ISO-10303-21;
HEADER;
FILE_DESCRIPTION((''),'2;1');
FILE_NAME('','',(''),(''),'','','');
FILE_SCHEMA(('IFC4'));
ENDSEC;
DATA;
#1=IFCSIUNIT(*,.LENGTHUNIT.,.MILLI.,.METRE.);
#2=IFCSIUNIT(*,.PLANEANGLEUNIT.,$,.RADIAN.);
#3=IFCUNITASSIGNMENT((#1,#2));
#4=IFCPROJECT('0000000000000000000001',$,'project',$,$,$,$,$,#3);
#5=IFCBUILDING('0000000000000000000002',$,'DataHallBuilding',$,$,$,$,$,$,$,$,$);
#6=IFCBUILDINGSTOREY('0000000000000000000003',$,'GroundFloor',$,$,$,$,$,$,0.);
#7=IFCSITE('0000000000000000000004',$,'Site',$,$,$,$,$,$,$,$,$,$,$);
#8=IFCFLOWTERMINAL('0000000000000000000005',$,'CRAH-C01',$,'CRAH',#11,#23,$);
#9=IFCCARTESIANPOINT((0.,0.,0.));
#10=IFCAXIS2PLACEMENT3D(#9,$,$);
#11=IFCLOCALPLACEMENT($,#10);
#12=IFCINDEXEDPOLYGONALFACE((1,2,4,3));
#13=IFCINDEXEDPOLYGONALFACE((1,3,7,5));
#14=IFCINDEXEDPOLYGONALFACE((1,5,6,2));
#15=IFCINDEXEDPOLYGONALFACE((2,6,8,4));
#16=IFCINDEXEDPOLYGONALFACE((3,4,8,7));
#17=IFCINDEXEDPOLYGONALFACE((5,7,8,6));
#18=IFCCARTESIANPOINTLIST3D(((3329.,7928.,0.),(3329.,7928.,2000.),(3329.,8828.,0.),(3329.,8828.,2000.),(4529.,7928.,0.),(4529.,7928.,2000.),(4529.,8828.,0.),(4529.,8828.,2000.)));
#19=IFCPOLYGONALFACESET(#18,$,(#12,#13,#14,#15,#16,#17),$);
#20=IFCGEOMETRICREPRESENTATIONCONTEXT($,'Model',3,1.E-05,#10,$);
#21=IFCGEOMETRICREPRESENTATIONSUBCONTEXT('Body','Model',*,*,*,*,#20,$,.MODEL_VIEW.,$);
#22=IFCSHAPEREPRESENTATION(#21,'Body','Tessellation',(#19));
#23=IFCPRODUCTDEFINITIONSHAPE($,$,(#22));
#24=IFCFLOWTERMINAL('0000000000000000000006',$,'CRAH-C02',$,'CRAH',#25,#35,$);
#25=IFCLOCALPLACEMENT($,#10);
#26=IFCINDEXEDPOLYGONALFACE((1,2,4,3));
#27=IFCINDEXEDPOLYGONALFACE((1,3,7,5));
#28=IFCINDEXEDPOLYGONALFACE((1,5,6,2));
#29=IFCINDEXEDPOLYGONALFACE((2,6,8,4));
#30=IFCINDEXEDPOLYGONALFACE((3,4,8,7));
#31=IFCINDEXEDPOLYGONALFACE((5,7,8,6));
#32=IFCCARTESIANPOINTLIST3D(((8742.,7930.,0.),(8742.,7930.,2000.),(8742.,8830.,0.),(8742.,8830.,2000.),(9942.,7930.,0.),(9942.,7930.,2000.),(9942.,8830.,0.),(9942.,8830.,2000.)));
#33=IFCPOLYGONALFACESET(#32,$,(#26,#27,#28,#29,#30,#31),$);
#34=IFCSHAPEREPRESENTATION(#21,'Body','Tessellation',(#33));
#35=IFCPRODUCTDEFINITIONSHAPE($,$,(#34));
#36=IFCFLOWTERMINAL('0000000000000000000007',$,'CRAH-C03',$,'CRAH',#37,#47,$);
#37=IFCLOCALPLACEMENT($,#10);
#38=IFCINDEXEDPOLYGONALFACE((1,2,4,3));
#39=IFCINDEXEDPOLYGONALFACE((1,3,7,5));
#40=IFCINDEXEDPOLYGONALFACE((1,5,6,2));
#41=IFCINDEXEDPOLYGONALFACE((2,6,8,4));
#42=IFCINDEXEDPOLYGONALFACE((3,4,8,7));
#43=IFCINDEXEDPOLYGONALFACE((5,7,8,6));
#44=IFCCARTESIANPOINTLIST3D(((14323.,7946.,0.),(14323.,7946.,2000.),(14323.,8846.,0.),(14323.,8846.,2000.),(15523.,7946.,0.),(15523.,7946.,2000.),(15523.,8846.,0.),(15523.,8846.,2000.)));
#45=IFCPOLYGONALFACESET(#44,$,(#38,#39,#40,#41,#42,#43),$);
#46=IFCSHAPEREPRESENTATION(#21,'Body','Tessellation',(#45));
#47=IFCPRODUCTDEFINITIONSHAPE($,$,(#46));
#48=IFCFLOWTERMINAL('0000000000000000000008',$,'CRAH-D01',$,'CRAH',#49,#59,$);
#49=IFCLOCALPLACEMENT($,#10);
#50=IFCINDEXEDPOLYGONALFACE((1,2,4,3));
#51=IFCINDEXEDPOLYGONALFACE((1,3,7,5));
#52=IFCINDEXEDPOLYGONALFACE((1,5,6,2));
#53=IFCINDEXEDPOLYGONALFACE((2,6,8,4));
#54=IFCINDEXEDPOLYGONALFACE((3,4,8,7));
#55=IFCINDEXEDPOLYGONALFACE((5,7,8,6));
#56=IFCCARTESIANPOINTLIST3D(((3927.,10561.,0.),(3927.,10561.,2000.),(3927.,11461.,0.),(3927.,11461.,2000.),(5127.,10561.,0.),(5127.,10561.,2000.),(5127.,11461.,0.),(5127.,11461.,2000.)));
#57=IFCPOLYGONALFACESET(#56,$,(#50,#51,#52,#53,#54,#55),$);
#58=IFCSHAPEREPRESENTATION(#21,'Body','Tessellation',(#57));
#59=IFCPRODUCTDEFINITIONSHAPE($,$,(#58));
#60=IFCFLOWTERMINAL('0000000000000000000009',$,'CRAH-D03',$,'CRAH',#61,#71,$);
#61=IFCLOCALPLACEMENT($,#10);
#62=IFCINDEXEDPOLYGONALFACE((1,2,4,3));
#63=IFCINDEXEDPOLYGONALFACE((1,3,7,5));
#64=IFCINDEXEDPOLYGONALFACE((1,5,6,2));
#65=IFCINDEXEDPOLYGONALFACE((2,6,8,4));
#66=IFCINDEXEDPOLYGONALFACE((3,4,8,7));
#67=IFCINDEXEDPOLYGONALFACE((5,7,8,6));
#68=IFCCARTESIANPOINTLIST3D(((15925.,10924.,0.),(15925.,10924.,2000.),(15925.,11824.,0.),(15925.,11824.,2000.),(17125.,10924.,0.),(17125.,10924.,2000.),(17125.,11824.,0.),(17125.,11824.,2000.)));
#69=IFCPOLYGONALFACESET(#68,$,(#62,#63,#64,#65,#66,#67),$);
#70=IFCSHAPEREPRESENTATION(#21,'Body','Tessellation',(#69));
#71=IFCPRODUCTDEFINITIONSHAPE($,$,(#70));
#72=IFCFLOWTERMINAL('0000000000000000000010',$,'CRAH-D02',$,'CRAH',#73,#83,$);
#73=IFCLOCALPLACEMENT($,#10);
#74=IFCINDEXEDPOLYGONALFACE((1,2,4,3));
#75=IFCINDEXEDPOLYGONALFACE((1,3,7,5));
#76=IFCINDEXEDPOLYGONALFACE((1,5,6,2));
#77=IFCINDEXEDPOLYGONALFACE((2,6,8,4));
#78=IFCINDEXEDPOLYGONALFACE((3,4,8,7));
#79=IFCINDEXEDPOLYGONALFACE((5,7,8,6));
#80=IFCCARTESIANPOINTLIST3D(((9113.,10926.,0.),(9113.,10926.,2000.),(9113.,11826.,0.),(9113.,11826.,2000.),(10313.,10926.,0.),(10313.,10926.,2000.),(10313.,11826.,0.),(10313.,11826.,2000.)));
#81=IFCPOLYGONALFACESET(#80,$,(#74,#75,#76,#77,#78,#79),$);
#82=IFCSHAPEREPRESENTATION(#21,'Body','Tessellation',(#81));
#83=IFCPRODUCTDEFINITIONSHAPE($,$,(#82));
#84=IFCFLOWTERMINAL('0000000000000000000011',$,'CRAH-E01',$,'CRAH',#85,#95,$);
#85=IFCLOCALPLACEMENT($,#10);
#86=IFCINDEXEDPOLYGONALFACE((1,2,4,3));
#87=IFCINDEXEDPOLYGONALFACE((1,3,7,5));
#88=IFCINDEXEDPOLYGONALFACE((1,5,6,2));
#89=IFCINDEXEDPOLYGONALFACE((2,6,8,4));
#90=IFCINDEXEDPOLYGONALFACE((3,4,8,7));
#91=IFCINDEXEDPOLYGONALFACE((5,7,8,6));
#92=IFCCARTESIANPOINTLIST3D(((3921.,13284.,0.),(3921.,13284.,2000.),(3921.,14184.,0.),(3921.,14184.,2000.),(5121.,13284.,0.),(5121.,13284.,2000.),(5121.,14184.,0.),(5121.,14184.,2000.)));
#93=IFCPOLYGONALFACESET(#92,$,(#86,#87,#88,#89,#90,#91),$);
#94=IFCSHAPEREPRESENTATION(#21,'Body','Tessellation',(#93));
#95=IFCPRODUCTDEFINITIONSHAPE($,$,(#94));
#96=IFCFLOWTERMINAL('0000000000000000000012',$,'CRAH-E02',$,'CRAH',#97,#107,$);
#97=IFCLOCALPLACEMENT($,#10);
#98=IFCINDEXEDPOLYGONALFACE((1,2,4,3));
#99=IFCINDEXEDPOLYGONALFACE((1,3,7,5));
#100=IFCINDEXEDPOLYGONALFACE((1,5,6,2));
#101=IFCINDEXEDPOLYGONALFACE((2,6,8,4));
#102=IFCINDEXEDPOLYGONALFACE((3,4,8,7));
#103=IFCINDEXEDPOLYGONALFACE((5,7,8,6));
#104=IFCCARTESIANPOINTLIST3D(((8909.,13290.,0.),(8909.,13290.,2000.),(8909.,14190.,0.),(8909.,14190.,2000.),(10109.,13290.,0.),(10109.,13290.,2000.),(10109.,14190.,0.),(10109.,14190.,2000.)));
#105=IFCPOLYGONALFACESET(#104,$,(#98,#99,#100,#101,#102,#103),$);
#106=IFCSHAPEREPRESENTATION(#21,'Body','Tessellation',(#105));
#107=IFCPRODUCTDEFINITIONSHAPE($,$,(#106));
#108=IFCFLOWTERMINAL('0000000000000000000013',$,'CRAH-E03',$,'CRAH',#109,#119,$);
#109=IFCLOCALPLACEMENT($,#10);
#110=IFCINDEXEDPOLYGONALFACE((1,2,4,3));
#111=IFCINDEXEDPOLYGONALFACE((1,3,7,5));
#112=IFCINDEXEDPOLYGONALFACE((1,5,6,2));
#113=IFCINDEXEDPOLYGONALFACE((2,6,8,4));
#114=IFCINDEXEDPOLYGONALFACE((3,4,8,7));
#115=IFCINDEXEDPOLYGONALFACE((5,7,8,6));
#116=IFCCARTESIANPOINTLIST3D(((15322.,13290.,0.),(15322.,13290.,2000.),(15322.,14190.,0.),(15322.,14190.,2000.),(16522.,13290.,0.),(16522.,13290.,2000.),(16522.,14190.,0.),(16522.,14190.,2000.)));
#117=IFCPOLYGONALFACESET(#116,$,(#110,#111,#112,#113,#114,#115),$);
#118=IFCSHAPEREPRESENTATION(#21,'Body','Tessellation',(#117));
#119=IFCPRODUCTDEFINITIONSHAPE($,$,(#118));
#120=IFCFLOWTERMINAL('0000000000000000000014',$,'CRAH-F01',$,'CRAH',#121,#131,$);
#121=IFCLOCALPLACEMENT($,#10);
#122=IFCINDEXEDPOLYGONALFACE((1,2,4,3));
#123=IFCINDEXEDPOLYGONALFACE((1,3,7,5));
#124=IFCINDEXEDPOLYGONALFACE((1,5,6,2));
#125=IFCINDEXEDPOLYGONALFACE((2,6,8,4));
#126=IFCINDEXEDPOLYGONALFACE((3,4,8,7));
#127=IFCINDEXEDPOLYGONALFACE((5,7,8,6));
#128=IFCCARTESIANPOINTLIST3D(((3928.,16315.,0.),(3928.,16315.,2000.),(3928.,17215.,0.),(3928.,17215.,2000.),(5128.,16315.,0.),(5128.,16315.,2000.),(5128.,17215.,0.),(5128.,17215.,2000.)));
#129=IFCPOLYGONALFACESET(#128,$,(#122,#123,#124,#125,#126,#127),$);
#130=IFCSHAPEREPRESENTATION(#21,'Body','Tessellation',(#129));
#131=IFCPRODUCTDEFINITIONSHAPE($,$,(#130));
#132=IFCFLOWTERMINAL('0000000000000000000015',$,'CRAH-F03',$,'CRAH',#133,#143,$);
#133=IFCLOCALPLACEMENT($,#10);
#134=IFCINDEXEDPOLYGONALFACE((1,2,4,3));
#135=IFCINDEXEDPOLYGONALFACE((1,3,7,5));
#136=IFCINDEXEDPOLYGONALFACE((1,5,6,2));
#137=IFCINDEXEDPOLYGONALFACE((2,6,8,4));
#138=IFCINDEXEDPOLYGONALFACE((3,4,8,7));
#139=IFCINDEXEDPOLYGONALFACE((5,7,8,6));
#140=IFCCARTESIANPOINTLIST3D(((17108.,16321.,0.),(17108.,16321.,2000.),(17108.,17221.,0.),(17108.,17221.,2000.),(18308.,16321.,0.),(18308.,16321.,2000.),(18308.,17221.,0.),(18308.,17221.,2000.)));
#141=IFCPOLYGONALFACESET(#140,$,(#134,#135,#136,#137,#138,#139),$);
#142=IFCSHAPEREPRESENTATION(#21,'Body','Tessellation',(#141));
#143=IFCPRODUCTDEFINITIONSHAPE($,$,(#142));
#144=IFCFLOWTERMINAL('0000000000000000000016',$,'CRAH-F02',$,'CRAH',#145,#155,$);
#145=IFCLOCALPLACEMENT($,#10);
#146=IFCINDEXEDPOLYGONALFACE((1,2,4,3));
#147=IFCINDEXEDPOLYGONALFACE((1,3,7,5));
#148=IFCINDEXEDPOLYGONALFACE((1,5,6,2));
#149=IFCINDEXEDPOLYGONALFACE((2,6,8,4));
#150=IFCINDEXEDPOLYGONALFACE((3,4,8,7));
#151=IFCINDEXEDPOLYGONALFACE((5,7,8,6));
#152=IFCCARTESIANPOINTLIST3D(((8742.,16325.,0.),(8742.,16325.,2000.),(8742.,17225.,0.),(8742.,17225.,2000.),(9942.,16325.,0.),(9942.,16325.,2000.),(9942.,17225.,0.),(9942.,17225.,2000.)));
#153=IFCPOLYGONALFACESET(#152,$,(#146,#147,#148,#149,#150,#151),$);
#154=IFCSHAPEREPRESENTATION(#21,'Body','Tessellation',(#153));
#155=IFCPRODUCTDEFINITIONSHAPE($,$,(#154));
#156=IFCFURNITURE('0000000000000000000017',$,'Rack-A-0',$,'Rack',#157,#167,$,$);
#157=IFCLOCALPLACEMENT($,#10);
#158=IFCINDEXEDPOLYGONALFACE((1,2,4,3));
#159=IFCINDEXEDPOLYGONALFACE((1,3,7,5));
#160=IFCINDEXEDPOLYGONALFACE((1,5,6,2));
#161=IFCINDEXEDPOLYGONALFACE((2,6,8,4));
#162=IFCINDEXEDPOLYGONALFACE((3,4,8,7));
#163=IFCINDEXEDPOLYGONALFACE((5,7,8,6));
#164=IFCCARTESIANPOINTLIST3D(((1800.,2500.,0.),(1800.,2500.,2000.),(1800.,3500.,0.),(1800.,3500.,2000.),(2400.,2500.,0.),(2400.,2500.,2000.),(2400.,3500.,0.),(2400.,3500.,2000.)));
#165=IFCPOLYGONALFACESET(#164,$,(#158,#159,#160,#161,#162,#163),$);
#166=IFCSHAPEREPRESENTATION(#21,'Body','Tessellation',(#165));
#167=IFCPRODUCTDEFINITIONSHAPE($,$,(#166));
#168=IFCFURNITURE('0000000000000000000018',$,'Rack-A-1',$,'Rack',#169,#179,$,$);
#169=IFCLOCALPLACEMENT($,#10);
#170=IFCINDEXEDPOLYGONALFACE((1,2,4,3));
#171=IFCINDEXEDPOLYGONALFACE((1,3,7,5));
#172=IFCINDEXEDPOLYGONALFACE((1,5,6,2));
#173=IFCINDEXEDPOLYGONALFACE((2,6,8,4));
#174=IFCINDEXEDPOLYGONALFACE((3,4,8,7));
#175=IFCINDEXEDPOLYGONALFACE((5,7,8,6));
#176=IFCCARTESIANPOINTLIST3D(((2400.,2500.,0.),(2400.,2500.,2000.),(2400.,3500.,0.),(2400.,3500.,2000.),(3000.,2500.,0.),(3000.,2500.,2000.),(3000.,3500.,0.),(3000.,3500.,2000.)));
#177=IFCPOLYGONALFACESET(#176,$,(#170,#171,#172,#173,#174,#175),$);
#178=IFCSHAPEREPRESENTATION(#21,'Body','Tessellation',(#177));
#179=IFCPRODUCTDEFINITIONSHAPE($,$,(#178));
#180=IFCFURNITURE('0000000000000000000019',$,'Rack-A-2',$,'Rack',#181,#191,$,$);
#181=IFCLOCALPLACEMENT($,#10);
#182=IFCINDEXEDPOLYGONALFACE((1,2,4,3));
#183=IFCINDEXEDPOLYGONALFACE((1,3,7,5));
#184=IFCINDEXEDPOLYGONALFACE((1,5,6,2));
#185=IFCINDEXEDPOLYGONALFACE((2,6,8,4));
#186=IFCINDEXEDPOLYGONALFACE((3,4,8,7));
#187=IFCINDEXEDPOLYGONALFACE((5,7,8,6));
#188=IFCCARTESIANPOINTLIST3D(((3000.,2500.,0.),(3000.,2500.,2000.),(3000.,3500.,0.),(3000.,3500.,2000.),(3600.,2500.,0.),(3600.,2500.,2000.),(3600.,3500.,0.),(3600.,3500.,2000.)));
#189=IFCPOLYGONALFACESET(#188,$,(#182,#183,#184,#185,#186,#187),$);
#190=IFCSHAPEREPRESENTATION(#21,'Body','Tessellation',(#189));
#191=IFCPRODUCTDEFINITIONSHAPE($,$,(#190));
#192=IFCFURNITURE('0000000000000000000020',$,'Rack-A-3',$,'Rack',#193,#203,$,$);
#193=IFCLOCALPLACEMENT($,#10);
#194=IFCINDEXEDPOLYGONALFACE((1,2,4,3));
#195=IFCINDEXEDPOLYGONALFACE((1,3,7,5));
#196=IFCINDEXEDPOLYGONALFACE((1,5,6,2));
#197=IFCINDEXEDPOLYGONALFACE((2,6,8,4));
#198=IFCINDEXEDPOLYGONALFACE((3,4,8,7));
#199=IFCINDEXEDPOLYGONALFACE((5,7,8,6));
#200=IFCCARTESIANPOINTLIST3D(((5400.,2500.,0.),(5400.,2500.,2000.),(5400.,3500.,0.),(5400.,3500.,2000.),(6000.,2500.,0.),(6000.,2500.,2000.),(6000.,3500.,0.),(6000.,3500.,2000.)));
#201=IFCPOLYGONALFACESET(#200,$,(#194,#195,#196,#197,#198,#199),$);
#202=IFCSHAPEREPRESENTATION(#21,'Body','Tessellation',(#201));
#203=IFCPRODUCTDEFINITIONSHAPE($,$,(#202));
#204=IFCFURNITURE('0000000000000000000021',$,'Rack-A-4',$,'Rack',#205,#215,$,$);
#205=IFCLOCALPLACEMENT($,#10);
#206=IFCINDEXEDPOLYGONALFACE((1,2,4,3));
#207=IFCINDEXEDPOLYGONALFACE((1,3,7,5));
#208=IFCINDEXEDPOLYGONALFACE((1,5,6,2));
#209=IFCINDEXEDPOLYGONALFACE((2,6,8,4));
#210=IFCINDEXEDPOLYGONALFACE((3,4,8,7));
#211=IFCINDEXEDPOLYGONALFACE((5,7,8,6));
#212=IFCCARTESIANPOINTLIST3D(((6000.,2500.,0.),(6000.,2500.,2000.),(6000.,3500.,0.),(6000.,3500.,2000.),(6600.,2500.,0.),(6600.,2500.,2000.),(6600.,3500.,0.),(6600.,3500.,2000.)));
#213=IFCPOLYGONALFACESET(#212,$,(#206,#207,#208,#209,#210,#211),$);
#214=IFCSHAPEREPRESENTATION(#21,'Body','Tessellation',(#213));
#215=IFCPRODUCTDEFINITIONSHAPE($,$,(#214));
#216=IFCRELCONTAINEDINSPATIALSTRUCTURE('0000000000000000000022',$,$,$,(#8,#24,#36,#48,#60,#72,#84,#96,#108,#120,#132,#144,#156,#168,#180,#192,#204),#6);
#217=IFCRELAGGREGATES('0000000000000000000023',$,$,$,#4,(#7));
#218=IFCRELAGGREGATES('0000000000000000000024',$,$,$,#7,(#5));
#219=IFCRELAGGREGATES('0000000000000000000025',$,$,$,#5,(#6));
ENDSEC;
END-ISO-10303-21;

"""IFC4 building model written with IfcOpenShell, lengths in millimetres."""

from ifc_helpers import new_model, si_unit, frame, origin, place, context, subcontext, project, spatial, rectangle, extrude, element, save


model = new_model("IFC4")

# Units and contexts
model_context = context("Model", 3, precision=1e-05, world=origin())
body_context = subcontext(model_context, "Body", "Model", "MODEL_VIEW")
ifc_project = project(units=[si_unit("LENGTHUNIT", "METRE", prefix="MILLI"), si_unit("PLANEANGLEUNIT", "RADIAN")])

# Site, building, storey
site = spatial("IfcSite", under=ifc_project, Name="Site")
building = spatial("IfcBuilding", under=site, Name="DataHallBuilding")
storey = spatial("IfcBuildingStorey", under=building, Name="GroundFloor", Elevation=0.0)

# Flow terminals
flow_terminal_1_placement = place(None, origin())
element("IfcFlowTerminal", 1, at=flow_terminal_1_placement, inside=storey, Name="CRAH-C01", ObjectType="CRAH", context=body_context, shape_type="SweptSolid", body=[
    extrude(rectangle(XDim=1200.0, YDim=900.0), frame((3929.0, 8378.0, 0.0), z_axis=(0.0, 0.0, 1.0), x_axis=(1.0, 0.0, 0.0)), (0.0, 0.0, 1.0), 2000.0),
])
flow_terminal_2_placement = place(None, origin())
element("IfcFlowTerminal", 2, at=flow_terminal_2_placement, inside=storey, Name="CRAH-C02", ObjectType="CRAH", context=body_context, shape_type="SweptSolid", body=[
    extrude(rectangle(XDim=1200.0, YDim=900.0), frame((9342.0, 8380.0, 0.0), z_axis=(0.0, 0.0, 1.0), x_axis=(1.0, 0.0, 0.0)), (0.0, 0.0, 1.0), 2000.0),
])
flow_terminal_3_placement = place(None, origin())
element("IfcFlowTerminal", 3, at=flow_terminal_3_placement, inside=storey, Name="CRAH-C03", ObjectType="CRAH", context=body_context, shape_type="SweptSolid", body=[
    extrude(rectangle(XDim=1200.0, YDim=900.0), frame((14923.0, 8396.0, 0.0), z_axis=(0.0, 0.0, 1.0), x_axis=(1.0, 0.0, 0.0)), (0.0, 0.0, 1.0), 2000.0),
])
flow_terminal_4_placement = place(None, origin())
element("IfcFlowTerminal", 4, at=flow_terminal_4_placement, inside=storey, Name="CRAH-D01", ObjectType="CRAH", context=body_context, shape_type="SweptSolid", body=[
    extrude(rectangle(XDim=1200.0, YDim=900.0), frame((4527.0, 11011.0, 0.0), z_axis=(0.0, 0.0, 1.0), x_axis=(1.0, 0.0, 0.0)), (0.0, 0.0, 1.0), 2000.0),
])
flow_terminal_5_placement = place(None, origin())
element("IfcFlowTerminal", 5, at=flow_terminal_5_placement, inside=storey, Name="CRAH-D03", ObjectType="CRAH", context=body_context, shape_type="SweptSolid", body=[
    extrude(rectangle(XDim=1200.0, YDim=900.0), frame((16525.0, 11374.0, 0.0), z_axis=(0.0, 0.0, 1.0), x_axis=(1.0, 0.0, 0.0)), (0.0, 0.0, 1.0), 2000.0),
])
flow_terminal_6_placement = place(None, origin())
element("IfcFlowTerminal", 6, at=flow_terminal_6_placement, inside=storey, Name="CRAH-D02", ObjectType="CRAH", context=body_context, shape_type="SweptSolid", body=[
    extrude(rectangle(XDim=1200.0, YDim=900.0), frame((9713.0, 11376.0, 0.0), z_axis=(0.0, 0.0, 1.0), x_axis=(1.0, 0.0, 0.0)), (0.0, 0.0, 1.0), 2000.0),
])
flow_terminal_7_placement = place(None, origin())
element("IfcFlowTerminal", 7, at=flow_terminal_7_placement, inside=storey, Name="CRAH-E01", ObjectType="CRAH", context=body_context, shape_type="SweptSolid", body=[
    extrude(rectangle(XDim=1200.0, YDim=900.0), frame((4521.0, 13734.0, 0.0), z_axis=(0.0, 0.0, 1.0), x_axis=(1.0, 0.0, 0.0)), (0.0, 0.0, 1.0), 2000.0),
])
flow_terminal_8_placement = place(None, origin())
element("IfcFlowTerminal", 8, at=flow_terminal_8_placement, inside=storey, Name="CRAH-E02", ObjectType="CRAH", context=body_context, shape_type="SweptSolid", body=[
    extrude(rectangle(XDim=1200.0, YDim=900.0), frame((9509.0, 13740.0, 0.0), z_axis=(0.0, 0.0, 1.0), x_axis=(1.0, 0.0, 0.0)), (0.0, 0.0, 1.0), 2000.0),
])
flow_terminal_9_placement = place(None, origin())
element("IfcFlowTerminal", 9, at=flow_terminal_9_placement, inside=storey, Name="CRAH-E03", ObjectType="CRAH", context=body_context, shape_type="SweptSolid", body=[
    extrude(rectangle(XDim=1200.0, YDim=900.0), frame((15922.0, 13740.0, 0.0), z_axis=(0.0, 0.0, 1.0), x_axis=(1.0, 0.0, 0.0)), (0.0, 0.0, 1.0), 2000.0),
])
flow_terminal_10_placement = place(None, origin())
element("IfcFlowTerminal", 10, at=flow_terminal_10_placement, inside=storey, Name="CRAH-F01", ObjectType="CRAH", context=body_context, shape_type="SweptSolid", body=[
    extrude(rectangle(XDim=1200.0, YDim=900.0), frame((4528.0, 16765.0, 0.0), z_axis=(0.0, 0.0, 1.0), x_axis=(1.0, 0.0, 0.0)), (0.0, 0.0, 1.0), 2000.0),
])
flow_terminal_11_placement = place(None, origin())
element("IfcFlowTerminal", 11, at=flow_terminal_11_placement, inside=storey, Name="CRAH-F03", ObjectType="CRAH", context=body_context, shape_type="SweptSolid", body=[
    extrude(rectangle(XDim=1200.0, YDim=900.0), frame((17708.0, 16771.0, 0.0), z_axis=(0.0, 0.0, 1.0), x_axis=(1.0, 0.0, 0.0)), (0.0, 0.0, 1.0), 2000.0),
])
flow_terminal_12_placement = place(None, origin())
element("IfcFlowTerminal", 12, at=flow_terminal_12_placement, inside=storey, Name="CRAH-F02", ObjectType="CRAH", context=body_context, shape_type="SweptSolid", body=[
    extrude(rectangle(XDim=1200.0, YDim=900.0), frame((9342.0, 16775.0, 0.0), z_axis=(0.0, 0.0, 1.0), x_axis=(1.0, 0.0, 0.0)), (0.0, 0.0, 1.0), 2000.0),
])

# Furniture
furniture_1_placement = place(None, origin())
element("IfcFurniture", 13, at=furniture_1_placement, inside=storey, Name="Rack-A-0", ObjectType="Rack", context=body_context, shape_type="SweptSolid", body=[
    extrude(rectangle(XDim=600.0, YDim=1000.0), frame((2100.0, 3000.0, 0.0), z_axis=(0.0, 0.0, 1.0), x_axis=(1.0, 0.0, 0.0)), (0.0, 0.0, 1.0), 2000.0),
])
furniture_2_placement = place(None, origin())
element("IfcFurniture", 14, at=furniture_2_placement, inside=storey, Name="Rack-A-1", ObjectType="Rack", context=body_context, shape_type="SweptSolid", body=[
    extrude(rectangle(XDim=600.0, YDim=1000.0), frame((2700.0, 3000.0, 0.0), z_axis=(0.0, 0.0, 1.0), x_axis=(1.0, 0.0, 0.0)), (0.0, 0.0, 1.0), 2000.0),
])
furniture_3_placement = place(None, origin())
element("IfcFurniture", 15, at=furniture_3_placement, inside=storey, Name="Rack-A-2", ObjectType="Rack", context=body_context, shape_type="SweptSolid", body=[
    extrude(rectangle(XDim=600.0, YDim=1000.0), frame((3300.0, 3000.0, 0.0), z_axis=(0.0, 0.0, 1.0), x_axis=(1.0, 0.0, 0.0)), (0.0, 0.0, 1.0), 2000.0),
])
furniture_4_placement = place(None, origin())
element("IfcFurniture", 16, at=furniture_4_placement, inside=storey, Name="Rack-A-3", ObjectType="Rack", context=body_context, shape_type="SweptSolid", body=[
    extrude(rectangle(XDim=600.0, YDim=1000.0), frame((5700.0, 3000.0, 0.0), z_axis=(0.0, 0.0, 1.0), x_axis=(1.0, 0.0, 0.0)), (0.0, 0.0, 1.0), 2000.0),
])
furniture_5_placement = place(None, origin())
element("IfcFurniture", 17, at=furniture_5_placement, inside=storey, Name="Rack-A-4", ObjectType="Rack", context=body_context, shape_type="SweptSolid", body=[
    extrude(rectangle(XDim=600.0, YDim=1000.0), frame((6300.0, 3000.0, 0.0), z_axis=(0.0, 0.0, 1.0), x_axis=(1.0, 0.0, 0.0)), (0.0, 0.0, 1.0), 2000.0),
])

save(model, "model.ifc")
